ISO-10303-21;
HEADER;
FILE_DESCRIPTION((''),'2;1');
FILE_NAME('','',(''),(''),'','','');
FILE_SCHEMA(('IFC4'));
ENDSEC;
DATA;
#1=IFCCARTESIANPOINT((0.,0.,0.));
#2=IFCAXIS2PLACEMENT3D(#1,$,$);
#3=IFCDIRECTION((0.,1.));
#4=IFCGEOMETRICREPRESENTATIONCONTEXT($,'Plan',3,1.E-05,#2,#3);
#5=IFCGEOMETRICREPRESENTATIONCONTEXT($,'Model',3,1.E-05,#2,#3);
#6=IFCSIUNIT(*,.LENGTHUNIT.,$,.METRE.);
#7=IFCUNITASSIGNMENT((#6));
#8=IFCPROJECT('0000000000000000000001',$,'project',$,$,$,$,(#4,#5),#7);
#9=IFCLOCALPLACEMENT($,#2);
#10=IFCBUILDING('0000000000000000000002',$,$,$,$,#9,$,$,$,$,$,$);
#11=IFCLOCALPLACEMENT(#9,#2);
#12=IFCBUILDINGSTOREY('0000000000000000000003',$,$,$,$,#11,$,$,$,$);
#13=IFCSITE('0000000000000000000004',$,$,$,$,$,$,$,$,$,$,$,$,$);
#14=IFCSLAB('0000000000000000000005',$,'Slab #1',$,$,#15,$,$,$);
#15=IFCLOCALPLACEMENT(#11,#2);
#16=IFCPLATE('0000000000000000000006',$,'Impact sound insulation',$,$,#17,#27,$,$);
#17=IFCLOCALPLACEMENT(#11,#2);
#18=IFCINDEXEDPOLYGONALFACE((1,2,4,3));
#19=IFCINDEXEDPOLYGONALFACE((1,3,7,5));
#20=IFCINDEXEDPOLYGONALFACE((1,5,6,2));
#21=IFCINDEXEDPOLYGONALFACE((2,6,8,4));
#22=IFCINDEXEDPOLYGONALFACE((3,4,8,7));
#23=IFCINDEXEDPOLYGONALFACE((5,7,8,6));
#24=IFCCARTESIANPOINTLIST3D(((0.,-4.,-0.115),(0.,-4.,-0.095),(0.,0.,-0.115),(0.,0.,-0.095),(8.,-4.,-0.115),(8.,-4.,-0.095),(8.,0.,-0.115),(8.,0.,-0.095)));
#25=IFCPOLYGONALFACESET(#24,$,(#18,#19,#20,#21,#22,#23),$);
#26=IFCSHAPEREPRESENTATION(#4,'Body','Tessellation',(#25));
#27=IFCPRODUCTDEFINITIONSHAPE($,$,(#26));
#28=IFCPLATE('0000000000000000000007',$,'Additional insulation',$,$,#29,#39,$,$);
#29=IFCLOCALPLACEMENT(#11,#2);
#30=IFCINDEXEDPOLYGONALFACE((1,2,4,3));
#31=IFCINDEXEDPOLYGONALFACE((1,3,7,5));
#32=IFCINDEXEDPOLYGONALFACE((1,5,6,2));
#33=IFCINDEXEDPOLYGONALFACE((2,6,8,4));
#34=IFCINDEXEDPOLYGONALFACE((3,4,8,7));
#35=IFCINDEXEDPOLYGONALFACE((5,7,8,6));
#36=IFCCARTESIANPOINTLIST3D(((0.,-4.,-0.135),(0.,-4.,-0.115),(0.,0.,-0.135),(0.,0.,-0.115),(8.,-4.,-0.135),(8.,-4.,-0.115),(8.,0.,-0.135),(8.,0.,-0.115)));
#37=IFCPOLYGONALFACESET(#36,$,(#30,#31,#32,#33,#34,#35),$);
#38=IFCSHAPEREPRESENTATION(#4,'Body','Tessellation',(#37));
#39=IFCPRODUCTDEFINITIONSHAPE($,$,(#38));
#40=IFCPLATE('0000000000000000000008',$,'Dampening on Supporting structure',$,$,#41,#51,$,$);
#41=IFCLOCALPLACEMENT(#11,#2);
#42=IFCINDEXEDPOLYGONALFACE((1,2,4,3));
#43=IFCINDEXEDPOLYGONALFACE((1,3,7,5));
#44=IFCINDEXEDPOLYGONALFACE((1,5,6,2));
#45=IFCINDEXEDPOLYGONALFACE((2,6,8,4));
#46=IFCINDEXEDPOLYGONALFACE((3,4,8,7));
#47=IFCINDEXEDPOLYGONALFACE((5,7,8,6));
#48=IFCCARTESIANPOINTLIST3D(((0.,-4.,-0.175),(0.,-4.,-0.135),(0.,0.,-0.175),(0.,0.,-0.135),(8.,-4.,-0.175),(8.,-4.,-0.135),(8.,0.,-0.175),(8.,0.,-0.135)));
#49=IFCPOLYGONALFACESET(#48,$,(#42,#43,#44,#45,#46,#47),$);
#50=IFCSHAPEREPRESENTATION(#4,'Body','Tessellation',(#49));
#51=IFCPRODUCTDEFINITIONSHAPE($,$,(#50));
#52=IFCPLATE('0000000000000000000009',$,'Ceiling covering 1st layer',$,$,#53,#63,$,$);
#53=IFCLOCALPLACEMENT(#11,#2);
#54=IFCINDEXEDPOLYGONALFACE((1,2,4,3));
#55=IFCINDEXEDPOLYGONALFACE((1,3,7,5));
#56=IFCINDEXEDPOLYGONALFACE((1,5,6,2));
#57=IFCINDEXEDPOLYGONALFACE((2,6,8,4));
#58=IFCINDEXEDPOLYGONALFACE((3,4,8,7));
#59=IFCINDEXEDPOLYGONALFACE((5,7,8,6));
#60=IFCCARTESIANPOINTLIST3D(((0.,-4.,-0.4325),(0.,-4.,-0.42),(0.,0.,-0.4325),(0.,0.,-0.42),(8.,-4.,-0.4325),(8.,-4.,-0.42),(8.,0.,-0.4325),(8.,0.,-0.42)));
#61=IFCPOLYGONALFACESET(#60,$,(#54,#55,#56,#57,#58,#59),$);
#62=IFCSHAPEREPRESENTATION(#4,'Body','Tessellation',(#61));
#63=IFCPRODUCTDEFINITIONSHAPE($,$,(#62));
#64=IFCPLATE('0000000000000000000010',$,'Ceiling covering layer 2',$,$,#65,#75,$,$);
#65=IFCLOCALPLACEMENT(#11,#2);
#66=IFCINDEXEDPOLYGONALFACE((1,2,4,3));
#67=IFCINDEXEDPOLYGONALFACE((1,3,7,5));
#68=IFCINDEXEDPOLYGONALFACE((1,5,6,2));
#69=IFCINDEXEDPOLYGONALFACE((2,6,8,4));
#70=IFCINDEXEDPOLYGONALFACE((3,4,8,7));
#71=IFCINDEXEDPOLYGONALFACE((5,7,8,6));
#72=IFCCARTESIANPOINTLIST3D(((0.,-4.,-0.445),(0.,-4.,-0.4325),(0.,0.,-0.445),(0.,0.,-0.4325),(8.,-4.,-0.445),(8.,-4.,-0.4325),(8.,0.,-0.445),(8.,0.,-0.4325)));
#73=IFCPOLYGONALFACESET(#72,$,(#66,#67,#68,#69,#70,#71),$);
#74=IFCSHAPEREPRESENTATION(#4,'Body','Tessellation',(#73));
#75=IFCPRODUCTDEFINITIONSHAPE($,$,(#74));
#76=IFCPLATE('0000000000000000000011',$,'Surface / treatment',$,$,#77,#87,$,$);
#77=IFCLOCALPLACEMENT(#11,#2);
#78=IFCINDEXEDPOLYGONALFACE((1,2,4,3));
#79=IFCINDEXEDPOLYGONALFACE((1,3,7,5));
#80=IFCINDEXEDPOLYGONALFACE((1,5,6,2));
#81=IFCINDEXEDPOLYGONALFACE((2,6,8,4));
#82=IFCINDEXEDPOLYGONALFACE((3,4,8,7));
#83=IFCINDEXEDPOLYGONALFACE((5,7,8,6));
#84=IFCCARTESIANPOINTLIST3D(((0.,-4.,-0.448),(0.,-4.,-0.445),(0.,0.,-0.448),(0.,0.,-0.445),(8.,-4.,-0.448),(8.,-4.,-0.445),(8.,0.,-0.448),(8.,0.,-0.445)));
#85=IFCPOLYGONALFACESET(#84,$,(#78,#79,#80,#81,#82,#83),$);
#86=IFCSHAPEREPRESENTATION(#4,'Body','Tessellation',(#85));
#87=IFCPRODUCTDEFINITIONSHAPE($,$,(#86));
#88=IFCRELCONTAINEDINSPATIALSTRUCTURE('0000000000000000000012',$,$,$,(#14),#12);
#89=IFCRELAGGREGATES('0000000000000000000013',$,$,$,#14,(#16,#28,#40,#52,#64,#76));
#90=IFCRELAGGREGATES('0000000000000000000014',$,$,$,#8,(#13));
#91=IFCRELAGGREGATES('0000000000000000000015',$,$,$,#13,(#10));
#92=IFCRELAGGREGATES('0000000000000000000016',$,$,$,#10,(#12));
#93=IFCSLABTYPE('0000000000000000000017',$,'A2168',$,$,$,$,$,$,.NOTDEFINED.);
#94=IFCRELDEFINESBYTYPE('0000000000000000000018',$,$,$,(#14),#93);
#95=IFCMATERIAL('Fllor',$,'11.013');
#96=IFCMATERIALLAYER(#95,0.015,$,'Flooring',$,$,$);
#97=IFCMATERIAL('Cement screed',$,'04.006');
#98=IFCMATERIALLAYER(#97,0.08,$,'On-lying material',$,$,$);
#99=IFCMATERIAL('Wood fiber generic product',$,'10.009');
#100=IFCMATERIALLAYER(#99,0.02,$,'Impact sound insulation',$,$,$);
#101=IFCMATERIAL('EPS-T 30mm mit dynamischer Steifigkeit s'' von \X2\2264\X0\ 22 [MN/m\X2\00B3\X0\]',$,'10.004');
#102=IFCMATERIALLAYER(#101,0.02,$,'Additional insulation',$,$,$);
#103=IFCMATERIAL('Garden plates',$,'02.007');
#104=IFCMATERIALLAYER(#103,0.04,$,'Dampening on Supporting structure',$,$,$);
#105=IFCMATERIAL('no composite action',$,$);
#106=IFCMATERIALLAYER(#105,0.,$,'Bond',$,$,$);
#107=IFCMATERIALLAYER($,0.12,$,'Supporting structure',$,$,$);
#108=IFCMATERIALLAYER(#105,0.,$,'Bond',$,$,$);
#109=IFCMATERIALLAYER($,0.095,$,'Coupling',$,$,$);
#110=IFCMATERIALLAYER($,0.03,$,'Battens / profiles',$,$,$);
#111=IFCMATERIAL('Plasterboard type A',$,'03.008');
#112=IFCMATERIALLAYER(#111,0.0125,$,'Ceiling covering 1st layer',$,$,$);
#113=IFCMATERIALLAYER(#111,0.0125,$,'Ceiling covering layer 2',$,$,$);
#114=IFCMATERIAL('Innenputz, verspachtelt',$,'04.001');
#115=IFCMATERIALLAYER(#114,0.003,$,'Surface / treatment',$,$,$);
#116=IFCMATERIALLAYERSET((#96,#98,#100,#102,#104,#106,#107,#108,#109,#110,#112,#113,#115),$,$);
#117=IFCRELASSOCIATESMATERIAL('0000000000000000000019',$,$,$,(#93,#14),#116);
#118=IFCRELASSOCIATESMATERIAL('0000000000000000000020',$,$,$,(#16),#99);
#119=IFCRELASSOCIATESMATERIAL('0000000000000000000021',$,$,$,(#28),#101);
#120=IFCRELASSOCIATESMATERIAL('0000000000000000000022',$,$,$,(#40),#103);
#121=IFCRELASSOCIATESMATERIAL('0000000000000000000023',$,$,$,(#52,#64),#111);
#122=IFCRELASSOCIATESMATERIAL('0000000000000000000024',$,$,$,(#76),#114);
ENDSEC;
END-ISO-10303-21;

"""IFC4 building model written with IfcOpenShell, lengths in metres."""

from ifc_helpers import new_model, si_unit, direction, frame, frame_2d, origin, place, context, project, spatial, rectangle, extrude, material, layer, layer_set, type_object, element, aggregate, save


model = new_model("IFC4")

# Units and contexts
plan_context = context("Plan", 3, precision=1e-05, world=origin(), true_north=direction((0.0, 1.0)))
model_context = context("Model", 3, precision=1e-05, world=origin(), true_north=direction((0.0, 1.0)))
ifc_project = project(units=[si_unit("LENGTHUNIT", "METRE")], contexts=[plan_context, model_context])

# Site, building, storey
site = spatial("IfcSite", under=ifc_project)
building_placement = place(None, origin())
building = spatial("IfcBuilding", under=site, at=building_placement)
storey_placement = place(building_placement, origin())
storey = spatial("IfcBuildingStorey", under=building, at=storey_placement)

# Slab, plates
ifc_material_1 = material(Name="Fllor", Category="11.013")
ifc_layer_1 = layer(ifc_material_1, 0.015, Name="Flooring")
ifc_material_2 = material(Name="Cement screed", Category="04.006")
ifc_layer_2 = layer(ifc_material_2, 0.08, Name="On-lying material")
ifc_material_3 = material(Name="Wood fiber generic product", Category="10.009")
ifc_layer_3 = layer(ifc_material_3, 0.02, Name="Impact sound insulation")
ifc_material_4 = material(Name="EPS-T 30mm mit dynamischer Steifigkeit s' von ≤ 22 [MN/m³]", Category="10.004")
ifc_layer_4 = layer(ifc_material_4, 0.02, Name="Additional insulation")
ifc_material_5 = material(Name="Garden plates", Category="02.007")
ifc_layer_5 = layer(ifc_material_5, 0.04, Name="Dampening on Supporting structure")
ifc_material_6 = material(Name="no composite action")
ifc_layer_6 = layer(ifc_material_6, 0.0, Name="Bond")
ifc_layer_7 = layer(None, 0.12, Name="Supporting structure")
ifc_layer_8 = layer(ifc_material_6, 0.0, Name="Bond")
ifc_layer_9 = layer(None, 0.095, Name="Coupling")
ifc_layer_10 = layer(None, 0.03, Name="Battens / profiles")
ifc_material_7 = material(Name="Plasterboard type A", Category="03.008")
ifc_layer_11 = layer(ifc_material_7, 0.0125, Name="Ceiling covering 1st layer")
ifc_layer_12 = layer(ifc_material_7, 0.0125, Name="Ceiling covering layer 2")
ifc_material_8 = material(Name="Innenputz, verspachtelt", Category="04.001")
ifc_layer_13 = layer(ifc_material_8, 0.003, Name="Surface / treatment")
ifc_layer_set = layer_set([ifc_layer_1, ifc_layer_2, ifc_layer_3, ifc_layer_4, ifc_layer_5, ifc_layer_6, ifc_layer_7, ifc_layer_8, ifc_layer_9, ifc_layer_10, ifc_layer_11, ifc_layer_12, ifc_layer_13])
slab_type = type_object("IfcSlabType", Name="A2168", PredefinedType="NOTDEFINED", material=ifc_layer_set)
slab_placement = place(None, frame((0.0, 0.0, 0.0), z_axis=(0.0, 0.0, -1.0), x_axis=(1.0, 0.0, 0.0)))
slab = element("IfcSlab", 1, at=slab_placement, inside=storey, type_object=slab_type, material=ifc_layer_set, Name="Slab #1")
plate_1_placement = place(slab_placement, origin())
plate_1 = element("IfcPlate", 2, at=plate_1_placement, material=ifc_material_3, Name="Impact sound insulation", context=plan_context, shape_type="SweptSolid", body=[
    extrude(rectangle(XDim=8.0, YDim=4.0, at=frame_2d((4.0, 2.0), x_axis=(1.0, 0.0))), frame((0.0, 0.0, 0.095), z_axis=(0.0, 0.0, 1.0), x_axis=(1.0, 0.0, 0.0)), (0.0, 0.0, 1.0), 0.02),
])
plate_2_placement = place(slab_placement, origin())
plate_2 = element("IfcPlate", 3, at=plate_2_placement, material=ifc_material_4, Name="Additional insulation", context=plan_context, shape_type="SweptSolid", body=[
    extrude(rectangle(XDim=8.0, YDim=4.0, at=frame_2d((4.0, 2.0), x_axis=(1.0, 0.0))), frame((0.0, 0.0, 0.115), z_axis=(0.0, 0.0, 1.0), x_axis=(1.0, 0.0, 0.0)), (0.0, 0.0, 1.0), 0.02),
])
plate_3_placement = place(slab_placement, origin())
plate_3 = element("IfcPlate", 4, at=plate_3_placement, material=ifc_material_5, Name="Dampening on Supporting structure", context=plan_context, shape_type="SweptSolid", body=[
    extrude(rectangle(XDim=8.0, YDim=4.0, at=frame_2d((4.0, 2.0), x_axis=(1.0, 0.0))), frame((0.0, 0.0, 0.135), z_axis=(0.0, 0.0, 1.0), x_axis=(1.0, 0.0, 0.0)), (0.0, 0.0, 1.0), 0.04),
])
plate_4_placement = place(slab_placement, origin())
plate_4 = element("IfcPlate", 5, at=plate_4_placement, material=ifc_material_7, Name="Ceiling covering 1st layer", context=plan_context, shape_type="SweptSolid", body=[
    extrude(rectangle(XDim=8.0, YDim=4.0, at=frame_2d((4.0, 2.0), x_axis=(1.0, 0.0))), frame((0.0, 0.0, 0.42), z_axis=(0.0, 0.0, 1.0), x_axis=(1.0, 0.0, 0.0)), (0.0, 0.0, 1.0), 0.0125),
])
plate_5_placement = place(slab_placement, origin())
plate_5 = element("IfcPlate", 6, at=plate_5_placement, material=ifc_material_7, Name="Ceiling covering layer 2", context=plan_context, shape_type="SweptSolid", body=[
    extrude(rectangle(XDim=8.0, YDim=4.0, at=frame_2d((4.0, 2.0), x_axis=(1.0, 0.0))), frame((0.0, 0.0, 0.4325), z_axis=(0.0, 0.0, 1.0), x_axis=(1.0, 0.0, 0.0)), (0.0, 0.0, 1.0), 0.0125),
])
plate_6_placement = place(slab_placement, origin())
plate_6 = element("IfcPlate", 7, at=plate_6_placement, material=ifc_material_8, Name="Surface / treatment", context=plan_context, shape_type="SweptSolid", body=[
    extrude(rectangle(XDim=8.0, YDim=4.0, at=frame_2d((4.0, 2.0), x_axis=(1.0, 0.0))), frame((0.0, 0.0, 0.445), z_axis=(0.0, 0.0, 1.0), x_axis=(1.0, 0.0, 0.0)), (0.0, 0.0, 1.0), 0.003),
])
aggregate(slab, [plate_1, plate_2, plate_3, plate_4, plate_5, plate_6])

save(model, "model.ifc")
